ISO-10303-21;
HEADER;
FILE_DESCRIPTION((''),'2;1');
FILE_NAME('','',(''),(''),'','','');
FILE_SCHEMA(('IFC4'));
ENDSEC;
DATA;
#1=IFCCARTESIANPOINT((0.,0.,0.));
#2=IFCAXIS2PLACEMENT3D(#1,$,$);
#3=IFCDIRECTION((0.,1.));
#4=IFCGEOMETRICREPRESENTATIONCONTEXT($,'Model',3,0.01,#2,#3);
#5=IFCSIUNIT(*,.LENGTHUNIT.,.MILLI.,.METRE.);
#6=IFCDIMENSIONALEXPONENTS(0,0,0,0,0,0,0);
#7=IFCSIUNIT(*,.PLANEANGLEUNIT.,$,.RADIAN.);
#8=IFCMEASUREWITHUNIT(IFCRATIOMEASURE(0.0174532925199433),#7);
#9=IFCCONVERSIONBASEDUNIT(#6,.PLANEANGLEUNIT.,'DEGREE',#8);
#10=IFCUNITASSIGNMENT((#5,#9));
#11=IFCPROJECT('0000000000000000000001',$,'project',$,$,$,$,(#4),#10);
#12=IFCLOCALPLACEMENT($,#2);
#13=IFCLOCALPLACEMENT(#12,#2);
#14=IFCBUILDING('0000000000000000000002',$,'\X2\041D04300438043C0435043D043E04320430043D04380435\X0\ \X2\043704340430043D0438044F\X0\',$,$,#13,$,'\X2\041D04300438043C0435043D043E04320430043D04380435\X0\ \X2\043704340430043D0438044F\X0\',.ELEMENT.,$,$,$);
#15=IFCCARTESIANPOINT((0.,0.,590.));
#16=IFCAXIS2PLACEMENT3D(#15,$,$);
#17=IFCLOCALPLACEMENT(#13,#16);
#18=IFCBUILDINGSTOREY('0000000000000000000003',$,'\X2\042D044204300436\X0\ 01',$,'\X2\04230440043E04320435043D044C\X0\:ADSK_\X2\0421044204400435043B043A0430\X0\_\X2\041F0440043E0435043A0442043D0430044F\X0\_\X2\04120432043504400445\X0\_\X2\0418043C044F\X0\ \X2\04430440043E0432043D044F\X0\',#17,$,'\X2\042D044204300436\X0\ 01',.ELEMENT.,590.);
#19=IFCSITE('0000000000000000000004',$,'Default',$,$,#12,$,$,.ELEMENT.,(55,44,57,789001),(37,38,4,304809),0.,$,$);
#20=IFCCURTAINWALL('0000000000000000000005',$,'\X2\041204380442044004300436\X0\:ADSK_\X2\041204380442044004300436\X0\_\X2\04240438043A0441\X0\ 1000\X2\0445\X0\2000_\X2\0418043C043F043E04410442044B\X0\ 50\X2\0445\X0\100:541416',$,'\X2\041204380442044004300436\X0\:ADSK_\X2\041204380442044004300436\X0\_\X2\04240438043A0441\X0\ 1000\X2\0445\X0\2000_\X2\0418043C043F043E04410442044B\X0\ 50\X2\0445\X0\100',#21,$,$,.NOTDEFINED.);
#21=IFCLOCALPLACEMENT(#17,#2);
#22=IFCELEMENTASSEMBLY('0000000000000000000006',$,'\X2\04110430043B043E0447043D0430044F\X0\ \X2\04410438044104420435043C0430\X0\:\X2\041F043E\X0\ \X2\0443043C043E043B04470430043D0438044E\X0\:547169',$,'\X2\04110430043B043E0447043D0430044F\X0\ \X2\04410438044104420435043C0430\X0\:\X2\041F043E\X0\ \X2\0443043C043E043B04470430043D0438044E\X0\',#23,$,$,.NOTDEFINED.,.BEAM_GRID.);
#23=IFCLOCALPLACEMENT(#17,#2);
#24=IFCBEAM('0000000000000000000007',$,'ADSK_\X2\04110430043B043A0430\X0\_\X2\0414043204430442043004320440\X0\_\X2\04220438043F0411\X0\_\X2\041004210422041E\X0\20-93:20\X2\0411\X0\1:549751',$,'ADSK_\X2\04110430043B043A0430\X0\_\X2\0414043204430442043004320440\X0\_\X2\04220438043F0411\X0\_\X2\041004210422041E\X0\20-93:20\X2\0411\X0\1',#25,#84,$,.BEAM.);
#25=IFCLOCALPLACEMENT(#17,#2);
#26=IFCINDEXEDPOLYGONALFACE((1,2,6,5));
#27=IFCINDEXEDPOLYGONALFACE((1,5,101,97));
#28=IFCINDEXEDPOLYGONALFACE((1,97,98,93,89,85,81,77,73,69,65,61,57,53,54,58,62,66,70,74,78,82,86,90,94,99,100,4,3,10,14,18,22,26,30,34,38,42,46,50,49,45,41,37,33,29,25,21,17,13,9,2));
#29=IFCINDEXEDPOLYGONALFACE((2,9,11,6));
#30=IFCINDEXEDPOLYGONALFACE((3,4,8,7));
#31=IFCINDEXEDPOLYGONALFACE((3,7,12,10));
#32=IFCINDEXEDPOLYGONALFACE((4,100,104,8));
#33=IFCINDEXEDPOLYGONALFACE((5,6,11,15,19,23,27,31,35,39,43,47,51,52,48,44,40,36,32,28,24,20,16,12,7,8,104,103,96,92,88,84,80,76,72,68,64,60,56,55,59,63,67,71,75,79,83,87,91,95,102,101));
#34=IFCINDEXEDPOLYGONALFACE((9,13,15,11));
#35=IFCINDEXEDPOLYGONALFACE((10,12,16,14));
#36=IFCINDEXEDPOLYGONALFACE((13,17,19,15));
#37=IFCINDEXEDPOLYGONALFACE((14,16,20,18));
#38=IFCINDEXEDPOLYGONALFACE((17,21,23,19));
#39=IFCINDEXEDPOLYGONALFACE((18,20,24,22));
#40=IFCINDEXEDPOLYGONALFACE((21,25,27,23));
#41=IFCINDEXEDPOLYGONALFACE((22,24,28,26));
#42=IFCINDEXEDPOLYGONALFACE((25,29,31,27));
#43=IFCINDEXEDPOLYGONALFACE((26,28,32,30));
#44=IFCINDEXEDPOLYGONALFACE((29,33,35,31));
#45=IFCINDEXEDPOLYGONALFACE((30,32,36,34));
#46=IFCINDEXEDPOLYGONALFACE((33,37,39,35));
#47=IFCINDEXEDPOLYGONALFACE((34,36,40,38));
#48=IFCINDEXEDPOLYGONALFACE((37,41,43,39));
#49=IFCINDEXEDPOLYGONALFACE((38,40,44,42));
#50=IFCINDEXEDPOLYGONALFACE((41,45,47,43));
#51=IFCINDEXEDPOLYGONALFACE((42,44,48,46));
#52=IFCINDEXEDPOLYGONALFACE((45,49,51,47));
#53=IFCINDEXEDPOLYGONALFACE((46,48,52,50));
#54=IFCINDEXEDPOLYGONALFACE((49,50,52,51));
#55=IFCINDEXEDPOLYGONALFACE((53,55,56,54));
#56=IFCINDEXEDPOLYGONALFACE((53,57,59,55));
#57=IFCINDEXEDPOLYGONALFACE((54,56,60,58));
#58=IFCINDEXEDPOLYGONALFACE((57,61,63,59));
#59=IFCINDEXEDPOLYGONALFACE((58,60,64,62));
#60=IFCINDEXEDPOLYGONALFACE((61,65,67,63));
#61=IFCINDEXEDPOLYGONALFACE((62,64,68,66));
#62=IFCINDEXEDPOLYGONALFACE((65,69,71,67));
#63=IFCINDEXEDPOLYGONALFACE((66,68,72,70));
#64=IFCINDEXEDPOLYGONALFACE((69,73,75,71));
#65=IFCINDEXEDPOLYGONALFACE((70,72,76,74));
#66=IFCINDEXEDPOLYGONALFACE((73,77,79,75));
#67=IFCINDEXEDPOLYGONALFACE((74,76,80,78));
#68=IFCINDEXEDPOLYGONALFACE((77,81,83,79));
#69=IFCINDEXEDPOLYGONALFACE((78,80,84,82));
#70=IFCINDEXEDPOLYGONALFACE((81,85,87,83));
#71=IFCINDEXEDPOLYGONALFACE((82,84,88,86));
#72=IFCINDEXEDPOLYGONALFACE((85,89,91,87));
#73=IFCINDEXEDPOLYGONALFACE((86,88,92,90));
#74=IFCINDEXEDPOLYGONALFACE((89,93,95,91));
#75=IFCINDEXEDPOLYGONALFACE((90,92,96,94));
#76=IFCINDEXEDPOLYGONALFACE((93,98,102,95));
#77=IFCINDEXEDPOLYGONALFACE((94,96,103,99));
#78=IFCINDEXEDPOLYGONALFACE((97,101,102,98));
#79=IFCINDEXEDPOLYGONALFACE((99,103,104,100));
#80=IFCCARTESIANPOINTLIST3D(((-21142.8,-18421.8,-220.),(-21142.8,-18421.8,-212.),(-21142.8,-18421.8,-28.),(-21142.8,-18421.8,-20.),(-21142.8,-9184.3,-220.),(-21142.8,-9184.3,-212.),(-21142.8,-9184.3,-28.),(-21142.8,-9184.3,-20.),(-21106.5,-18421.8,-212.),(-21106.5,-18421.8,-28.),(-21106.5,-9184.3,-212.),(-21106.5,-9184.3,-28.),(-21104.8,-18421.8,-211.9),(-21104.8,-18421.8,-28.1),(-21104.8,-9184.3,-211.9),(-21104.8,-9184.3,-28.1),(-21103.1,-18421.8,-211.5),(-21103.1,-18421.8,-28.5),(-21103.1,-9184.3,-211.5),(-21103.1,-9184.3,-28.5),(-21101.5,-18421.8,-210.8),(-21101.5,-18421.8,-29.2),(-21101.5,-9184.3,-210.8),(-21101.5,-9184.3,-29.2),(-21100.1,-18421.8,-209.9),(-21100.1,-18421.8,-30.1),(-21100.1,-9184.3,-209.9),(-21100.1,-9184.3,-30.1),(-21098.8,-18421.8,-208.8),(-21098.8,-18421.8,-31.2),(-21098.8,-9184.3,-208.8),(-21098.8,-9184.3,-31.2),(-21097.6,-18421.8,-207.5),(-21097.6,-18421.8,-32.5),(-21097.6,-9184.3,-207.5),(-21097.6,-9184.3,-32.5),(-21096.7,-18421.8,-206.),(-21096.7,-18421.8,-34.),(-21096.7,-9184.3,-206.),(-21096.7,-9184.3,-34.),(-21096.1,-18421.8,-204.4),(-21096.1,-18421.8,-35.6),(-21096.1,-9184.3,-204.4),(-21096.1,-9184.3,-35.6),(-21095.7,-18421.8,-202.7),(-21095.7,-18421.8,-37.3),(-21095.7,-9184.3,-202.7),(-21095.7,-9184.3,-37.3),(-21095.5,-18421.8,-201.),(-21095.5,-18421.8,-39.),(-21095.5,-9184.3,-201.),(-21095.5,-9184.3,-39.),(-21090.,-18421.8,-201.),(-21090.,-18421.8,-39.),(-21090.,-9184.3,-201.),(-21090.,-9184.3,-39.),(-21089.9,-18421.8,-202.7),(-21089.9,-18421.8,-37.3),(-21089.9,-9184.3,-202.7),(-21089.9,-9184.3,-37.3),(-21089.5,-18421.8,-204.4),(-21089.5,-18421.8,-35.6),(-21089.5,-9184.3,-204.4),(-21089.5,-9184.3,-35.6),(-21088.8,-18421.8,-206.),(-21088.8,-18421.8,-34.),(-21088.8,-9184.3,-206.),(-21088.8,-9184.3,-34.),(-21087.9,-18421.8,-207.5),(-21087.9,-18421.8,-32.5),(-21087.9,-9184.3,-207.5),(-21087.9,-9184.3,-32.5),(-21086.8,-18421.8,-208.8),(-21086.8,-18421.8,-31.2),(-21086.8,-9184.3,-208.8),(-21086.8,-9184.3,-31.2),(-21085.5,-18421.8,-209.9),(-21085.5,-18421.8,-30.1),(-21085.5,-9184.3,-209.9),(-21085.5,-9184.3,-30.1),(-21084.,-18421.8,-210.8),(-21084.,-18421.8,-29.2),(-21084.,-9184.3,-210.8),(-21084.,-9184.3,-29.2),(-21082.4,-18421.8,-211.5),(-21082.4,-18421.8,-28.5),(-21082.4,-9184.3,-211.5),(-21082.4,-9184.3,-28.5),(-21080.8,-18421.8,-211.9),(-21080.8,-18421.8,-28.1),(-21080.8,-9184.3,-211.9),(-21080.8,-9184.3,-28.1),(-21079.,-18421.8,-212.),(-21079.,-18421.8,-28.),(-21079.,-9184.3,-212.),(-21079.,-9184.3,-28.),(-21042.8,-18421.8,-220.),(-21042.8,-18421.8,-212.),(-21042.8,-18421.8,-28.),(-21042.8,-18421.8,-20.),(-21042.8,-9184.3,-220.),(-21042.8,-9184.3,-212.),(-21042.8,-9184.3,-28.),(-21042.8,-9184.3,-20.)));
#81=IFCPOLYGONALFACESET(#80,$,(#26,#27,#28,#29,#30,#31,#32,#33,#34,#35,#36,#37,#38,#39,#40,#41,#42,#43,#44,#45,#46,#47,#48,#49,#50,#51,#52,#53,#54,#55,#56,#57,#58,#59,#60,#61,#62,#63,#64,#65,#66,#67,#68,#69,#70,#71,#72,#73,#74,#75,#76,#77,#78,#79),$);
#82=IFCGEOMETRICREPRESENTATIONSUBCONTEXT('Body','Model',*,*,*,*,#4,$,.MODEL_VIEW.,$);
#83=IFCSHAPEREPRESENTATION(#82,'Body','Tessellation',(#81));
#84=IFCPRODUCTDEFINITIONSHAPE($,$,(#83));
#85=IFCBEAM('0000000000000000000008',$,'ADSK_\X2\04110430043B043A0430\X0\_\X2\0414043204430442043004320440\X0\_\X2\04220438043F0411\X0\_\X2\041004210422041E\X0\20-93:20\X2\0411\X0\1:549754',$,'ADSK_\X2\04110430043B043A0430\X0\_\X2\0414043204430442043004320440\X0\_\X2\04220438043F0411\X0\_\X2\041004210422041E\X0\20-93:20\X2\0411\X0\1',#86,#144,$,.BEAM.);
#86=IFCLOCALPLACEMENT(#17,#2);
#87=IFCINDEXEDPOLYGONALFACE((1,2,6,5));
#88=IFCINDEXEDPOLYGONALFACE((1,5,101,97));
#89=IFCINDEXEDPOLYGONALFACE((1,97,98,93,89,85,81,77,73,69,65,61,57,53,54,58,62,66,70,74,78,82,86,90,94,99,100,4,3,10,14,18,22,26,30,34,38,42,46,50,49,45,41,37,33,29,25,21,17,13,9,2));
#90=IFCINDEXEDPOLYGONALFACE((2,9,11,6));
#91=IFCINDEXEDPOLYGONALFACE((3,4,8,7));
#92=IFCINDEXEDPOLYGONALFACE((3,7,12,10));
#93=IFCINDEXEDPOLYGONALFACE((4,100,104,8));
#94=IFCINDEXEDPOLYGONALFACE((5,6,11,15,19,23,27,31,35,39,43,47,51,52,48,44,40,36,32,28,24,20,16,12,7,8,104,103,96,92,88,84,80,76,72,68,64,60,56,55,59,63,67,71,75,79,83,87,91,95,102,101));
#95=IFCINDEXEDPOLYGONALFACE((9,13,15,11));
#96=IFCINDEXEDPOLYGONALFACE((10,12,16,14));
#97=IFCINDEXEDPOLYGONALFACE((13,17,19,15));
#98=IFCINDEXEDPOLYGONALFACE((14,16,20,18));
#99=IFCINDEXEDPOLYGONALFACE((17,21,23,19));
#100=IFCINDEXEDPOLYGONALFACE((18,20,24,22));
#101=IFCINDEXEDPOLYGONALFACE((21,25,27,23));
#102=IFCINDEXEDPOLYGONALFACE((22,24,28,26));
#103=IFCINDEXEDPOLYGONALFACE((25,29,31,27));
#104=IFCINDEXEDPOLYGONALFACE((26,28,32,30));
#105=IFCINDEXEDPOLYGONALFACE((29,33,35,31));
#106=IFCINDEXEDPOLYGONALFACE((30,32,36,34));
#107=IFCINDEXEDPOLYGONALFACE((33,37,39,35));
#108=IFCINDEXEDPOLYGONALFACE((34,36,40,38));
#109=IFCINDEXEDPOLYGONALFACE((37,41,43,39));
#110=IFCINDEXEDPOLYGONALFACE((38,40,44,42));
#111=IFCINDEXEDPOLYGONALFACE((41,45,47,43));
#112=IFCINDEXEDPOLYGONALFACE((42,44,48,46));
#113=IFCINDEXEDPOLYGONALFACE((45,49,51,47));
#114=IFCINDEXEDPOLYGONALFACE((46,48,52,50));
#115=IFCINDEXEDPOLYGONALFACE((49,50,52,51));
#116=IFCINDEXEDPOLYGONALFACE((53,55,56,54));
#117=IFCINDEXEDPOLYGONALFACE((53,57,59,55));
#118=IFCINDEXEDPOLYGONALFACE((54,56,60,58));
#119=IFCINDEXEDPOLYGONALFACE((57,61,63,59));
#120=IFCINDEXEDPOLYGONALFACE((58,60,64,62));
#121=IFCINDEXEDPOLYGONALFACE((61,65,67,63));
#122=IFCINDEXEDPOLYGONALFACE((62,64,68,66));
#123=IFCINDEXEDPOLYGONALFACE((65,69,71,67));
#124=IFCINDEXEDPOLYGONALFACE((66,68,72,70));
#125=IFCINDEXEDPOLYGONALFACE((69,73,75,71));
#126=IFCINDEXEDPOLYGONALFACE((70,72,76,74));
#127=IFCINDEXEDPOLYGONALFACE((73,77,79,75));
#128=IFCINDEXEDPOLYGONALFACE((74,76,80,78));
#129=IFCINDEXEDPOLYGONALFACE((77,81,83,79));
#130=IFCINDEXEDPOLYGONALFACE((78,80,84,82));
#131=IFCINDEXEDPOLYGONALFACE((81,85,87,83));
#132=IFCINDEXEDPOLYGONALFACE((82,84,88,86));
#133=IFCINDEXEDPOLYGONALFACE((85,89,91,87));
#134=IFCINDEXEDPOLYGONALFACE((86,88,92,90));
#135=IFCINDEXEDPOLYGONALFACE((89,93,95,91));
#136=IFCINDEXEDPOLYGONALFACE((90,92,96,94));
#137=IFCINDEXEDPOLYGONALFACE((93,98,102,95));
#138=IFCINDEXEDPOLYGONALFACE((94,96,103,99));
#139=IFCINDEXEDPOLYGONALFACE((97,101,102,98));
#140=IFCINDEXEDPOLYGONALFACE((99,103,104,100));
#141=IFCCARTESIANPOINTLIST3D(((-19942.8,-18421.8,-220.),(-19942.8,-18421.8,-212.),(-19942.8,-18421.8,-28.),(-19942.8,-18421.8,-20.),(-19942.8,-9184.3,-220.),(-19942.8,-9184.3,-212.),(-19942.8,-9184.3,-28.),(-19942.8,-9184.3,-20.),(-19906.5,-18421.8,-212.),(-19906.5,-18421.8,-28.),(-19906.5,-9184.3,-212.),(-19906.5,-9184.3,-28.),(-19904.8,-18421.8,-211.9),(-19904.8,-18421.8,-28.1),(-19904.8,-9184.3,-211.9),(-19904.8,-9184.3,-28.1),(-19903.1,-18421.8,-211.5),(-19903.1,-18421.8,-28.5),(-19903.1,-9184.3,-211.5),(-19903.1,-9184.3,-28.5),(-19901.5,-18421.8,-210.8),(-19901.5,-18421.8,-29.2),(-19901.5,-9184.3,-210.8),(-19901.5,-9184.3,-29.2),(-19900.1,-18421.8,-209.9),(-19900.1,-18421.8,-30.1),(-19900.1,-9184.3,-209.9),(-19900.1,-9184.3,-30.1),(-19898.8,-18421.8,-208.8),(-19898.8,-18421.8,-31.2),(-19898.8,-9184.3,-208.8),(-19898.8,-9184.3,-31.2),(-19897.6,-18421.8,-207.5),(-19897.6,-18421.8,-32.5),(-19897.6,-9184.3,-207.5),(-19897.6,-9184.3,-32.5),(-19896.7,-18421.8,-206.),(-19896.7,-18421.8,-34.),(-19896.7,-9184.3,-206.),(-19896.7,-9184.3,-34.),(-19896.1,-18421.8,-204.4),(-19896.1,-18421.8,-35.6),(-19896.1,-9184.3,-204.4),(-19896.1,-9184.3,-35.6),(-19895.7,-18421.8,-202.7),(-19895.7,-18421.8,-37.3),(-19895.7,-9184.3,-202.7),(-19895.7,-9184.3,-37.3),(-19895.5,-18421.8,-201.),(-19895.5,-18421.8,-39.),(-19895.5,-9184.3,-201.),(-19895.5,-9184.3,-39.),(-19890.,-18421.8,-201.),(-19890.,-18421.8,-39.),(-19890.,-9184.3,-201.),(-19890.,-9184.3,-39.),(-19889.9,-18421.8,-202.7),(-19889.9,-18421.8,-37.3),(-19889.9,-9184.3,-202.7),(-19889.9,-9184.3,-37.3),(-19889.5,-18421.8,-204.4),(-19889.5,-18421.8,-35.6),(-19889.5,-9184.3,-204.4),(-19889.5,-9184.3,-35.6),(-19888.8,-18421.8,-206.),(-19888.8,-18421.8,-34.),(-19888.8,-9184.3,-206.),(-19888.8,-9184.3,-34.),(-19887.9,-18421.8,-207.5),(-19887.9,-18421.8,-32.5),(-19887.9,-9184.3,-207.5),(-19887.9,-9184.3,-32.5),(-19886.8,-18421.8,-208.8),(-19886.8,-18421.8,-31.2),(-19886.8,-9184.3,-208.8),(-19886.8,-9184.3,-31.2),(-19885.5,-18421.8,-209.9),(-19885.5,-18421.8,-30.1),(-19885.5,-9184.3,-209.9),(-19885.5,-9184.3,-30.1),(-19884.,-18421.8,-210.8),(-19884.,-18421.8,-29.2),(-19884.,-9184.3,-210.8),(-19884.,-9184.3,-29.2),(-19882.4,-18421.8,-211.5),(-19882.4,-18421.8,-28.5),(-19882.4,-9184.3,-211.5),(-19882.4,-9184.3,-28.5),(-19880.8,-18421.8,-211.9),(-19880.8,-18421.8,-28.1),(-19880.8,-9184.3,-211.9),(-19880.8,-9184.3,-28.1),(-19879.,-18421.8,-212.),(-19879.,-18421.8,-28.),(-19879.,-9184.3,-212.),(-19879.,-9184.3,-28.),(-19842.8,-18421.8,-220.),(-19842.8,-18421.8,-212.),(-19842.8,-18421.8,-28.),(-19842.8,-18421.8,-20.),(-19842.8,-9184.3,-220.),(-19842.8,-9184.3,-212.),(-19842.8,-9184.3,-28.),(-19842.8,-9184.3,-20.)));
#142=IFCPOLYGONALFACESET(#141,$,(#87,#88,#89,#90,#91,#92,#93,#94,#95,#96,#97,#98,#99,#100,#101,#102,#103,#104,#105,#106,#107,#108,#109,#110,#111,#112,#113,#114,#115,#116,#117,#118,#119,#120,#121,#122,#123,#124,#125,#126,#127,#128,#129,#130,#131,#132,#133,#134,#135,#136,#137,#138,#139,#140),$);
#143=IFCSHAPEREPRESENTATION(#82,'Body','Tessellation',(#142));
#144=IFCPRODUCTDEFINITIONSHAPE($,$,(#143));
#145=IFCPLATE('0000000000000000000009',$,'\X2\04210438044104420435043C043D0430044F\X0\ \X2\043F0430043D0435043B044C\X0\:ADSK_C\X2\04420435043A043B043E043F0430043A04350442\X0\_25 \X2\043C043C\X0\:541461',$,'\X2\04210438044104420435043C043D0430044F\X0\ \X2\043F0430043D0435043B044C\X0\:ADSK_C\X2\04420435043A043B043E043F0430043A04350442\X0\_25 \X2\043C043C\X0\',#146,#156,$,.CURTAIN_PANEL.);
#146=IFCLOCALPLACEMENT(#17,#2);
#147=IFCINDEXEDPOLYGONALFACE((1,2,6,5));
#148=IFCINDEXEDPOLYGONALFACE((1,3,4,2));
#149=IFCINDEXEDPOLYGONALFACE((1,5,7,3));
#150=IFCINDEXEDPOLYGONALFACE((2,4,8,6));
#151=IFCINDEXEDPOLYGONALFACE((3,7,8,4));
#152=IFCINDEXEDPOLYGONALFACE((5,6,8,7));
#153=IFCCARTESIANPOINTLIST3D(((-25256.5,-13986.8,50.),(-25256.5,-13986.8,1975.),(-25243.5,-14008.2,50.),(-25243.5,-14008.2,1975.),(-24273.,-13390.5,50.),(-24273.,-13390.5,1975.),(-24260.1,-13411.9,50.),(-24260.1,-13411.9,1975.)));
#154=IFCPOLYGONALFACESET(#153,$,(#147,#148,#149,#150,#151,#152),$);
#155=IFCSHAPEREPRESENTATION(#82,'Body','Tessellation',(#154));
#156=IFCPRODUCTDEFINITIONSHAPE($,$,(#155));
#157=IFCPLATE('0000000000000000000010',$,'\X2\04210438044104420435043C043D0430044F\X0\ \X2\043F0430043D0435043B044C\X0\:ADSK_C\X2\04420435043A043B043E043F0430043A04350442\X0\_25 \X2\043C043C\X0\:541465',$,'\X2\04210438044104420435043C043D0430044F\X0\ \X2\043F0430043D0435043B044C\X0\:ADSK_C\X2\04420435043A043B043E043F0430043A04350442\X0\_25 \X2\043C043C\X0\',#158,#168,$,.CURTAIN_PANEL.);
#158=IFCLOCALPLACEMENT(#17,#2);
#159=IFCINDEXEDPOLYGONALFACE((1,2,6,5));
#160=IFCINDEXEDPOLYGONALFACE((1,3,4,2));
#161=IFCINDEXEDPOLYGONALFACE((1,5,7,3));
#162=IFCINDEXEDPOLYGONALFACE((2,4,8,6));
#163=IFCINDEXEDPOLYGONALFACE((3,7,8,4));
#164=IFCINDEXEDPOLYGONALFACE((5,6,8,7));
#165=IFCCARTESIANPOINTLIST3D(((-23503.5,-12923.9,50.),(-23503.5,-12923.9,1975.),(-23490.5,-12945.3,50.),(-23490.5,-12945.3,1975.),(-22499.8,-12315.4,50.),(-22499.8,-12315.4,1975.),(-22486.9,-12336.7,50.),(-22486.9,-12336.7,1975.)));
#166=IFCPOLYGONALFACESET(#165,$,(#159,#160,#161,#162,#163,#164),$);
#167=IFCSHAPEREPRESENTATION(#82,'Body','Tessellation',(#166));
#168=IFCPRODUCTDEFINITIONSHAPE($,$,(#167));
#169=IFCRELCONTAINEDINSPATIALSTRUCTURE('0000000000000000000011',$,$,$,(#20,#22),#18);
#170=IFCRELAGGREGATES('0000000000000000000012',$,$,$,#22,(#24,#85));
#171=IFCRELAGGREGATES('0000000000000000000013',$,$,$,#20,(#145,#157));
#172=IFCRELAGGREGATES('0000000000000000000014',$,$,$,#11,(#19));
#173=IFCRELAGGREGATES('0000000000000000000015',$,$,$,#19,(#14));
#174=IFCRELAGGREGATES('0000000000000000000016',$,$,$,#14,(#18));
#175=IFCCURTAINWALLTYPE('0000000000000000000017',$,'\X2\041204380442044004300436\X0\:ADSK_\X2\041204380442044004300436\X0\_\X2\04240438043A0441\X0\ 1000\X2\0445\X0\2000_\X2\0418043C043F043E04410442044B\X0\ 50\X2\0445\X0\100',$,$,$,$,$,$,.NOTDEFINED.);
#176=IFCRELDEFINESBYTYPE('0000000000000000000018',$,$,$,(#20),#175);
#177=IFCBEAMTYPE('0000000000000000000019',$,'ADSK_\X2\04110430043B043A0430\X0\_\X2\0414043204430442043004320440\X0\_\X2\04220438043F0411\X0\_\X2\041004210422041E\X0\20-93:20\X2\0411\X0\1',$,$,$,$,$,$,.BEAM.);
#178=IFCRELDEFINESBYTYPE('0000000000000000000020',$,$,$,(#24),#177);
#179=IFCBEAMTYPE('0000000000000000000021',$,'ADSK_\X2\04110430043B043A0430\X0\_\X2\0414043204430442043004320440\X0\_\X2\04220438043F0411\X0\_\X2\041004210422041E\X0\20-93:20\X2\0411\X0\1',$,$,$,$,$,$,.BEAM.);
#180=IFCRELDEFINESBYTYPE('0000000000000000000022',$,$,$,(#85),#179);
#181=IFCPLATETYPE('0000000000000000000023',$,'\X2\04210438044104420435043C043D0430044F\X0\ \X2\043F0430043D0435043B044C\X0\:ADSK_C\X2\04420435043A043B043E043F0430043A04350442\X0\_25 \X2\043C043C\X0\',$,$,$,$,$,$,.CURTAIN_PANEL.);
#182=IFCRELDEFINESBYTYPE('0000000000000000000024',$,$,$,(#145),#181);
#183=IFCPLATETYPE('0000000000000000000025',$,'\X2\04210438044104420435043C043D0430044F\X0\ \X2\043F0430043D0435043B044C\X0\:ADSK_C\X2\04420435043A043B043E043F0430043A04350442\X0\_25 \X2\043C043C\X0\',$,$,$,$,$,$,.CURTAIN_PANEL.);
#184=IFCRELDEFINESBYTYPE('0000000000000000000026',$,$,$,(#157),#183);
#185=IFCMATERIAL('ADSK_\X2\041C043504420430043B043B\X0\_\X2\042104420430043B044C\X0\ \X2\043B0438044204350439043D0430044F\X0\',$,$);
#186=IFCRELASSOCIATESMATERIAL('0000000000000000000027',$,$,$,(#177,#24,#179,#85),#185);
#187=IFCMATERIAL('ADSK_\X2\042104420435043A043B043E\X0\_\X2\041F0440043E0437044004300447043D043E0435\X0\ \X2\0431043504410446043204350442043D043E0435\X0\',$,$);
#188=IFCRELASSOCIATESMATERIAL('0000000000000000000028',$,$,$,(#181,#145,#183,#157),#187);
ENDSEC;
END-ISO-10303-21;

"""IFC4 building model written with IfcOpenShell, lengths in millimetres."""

from ifc_helpers import new_model, entity, si_unit, converted_unit, direction, frame, origin, place, context, subcontext, project, spatial, indexed_curve, outline, extrude, source, transform, mapped, material, type_object, type_shapes, element, aggregate, save


model = new_model("IFC4")

# Units and contexts
model_context = context("Model", 3, precision=0.01, world=origin(), true_north=direction((0.0, 1.0)))
body_context = subcontext(model_context, "Body", "Model", "MODEL_VIEW")
ifc_project = project(units=[si_unit("LENGTHUNIT", "METRE", prefix="MILLI"), converted_unit("PLANEANGLEUNIT", "DEGREE", entity("IfcRatioMeasure", 0.0174532925199433), si_unit("PLANEANGLEUNIT", "RADIAN"), dimensions=[0, 0, 0, 0, 0, 0, 0])], contexts=[model_context])

# Site, building, storey
site_placement = place(None, origin())
site = spatial("IfcSite", under=ifc_project, at=site_placement, Name="Default", CompositionType="ELEMENT", RefLatitude=(55, 44, 57, 789001), RefLongitude=(37, 38, 4, 304809), RefElevation=0.0)
building_placement = place(site_placement, origin())
building = spatial("IfcBuilding", under=site, at=building_placement, Name="Наименование здания", LongName="Наименование здания", CompositionType="ELEMENT")
storey_placement = place(building_placement, frame((0.0, 0.0, 590.0)))
storey = spatial("IfcBuildingStorey", under=building, at=storey_placement, Name="Этаж 01", ObjectType="Уровень:ADSK_Стрелка_Проектная_Вверх_Имя уровня", LongName="Этаж 01", CompositionType="ELEMENT", Elevation=590.0)

# Curtain wall
curtain_wall_type = type_object("IfcCurtainWallType", Name="Витраж:ADSK_Витраж_Фикс 1000х2000_Импосты 50х100", PredefinedType="NOTDEFINED")
curtain_wall_placement = place(storey_placement, frame((0.0, 0.0, -590.0)))
curtain_wall = element("IfcCurtainWall", 1, at=curtain_wall_placement, inside=storey, type_object=curtain_wall_type, Name="Витраж:ADSK_Витраж_Фикс 1000х2000_Импосты 50х100:541416", ObjectType="Витраж:ADSK_Витраж_Фикс 1000х2000_Импосты 50х100", PredefinedType="NOTDEFINED")

# Element assembly, beams
assembly_placement = place(storey_placement, origin())
assembly = element("IfcElementAssembly", 2, at=assembly_placement, inside=storey, Name="Балочная система:По умолчанию:547169", ObjectType="Балочная система:По умолчанию", AssemblyPlace="NOTDEFINED", PredefinedType="BEAM_GRID")
ifc_material_1 = material(Name="ADSK_Металл_Сталь литейная")
beam_type_1 = type_object("IfcBeamType", Name="ADSK_Балка_Двутавр_ТипБ_АСТО20-93:20Б1", PredefinedType="BEAM", material=ifc_material_1)
shared_shape_1 = source(origin(), body_context, "Body", "SweptSolid", [
    extrude(outline(indexed_curve([(-100.0, -50.0), (-92.0, -50.0), (-92.0, -13.8), (-91.9, -12.0), (-91.5, -10.4), (-90.8, -8.8), (-89.9, -7.3), (-88.8, -6.0), (-87.5, -4.9), (-86.0, -3.9), (-84.4, -3.3), (-82.7, -2.9), (-81.0, -2.8), (81.0, -2.8), (82.7, -2.9), (84.4, -3.3), (86.0, -3.9), (87.5, -4.9), (88.8, -6.0), (89.9, -7.3), (90.8, -8.8), (91.5, -10.4), (91.9, -12.0), (92.0, -13.7), (92.0, -50.0), (100.0, -50.0), (100.0, 50.0), (92.0, 50.0), (92.0, 13.8), (91.9, 12.0), (91.5, 10.4), (90.8, 8.8), (89.9, 7.3), (88.8, 6.0), (87.5, 4.9), (86.0, 3.9), (84.4, 3.3), (82.7, 2.9), (81.0, 2.8), (-81.0, 2.8), (-82.7, 2.9), (-84.4, 3.3), (-86.0, 3.9), (-87.5, 4.9), (-88.8, 6.0), (-89.9, 7.3), (-90.8, 8.8), (-91.5, 10.4), (-91.9, 12.0), (-92.0, 13.8), (-92.0, 50.0), (-100.0, 50.0), (-100.0, -50.0)], self_intersect=False)), frame((-4618.7, 0.0, -100.0), z_axis=(1.0, 0.0, 0.0), x_axis=(0.0, 0.0, -1.0)), (0.0, 0.0, 1.0), 9237.5),
])
type_shapes(beam_type_1, [shared_shape_1])
beam_1_placement = place(assembly_placement, frame((-21092.8, -13803.0, -20.0), z_axis=(0.0, 0.0, 1.0), x_axis=(0.0, 1.0, 0.0)))
beam_1 = element("IfcBeam", 3, at=beam_1_placement, type_object=beam_type_1, material=ifc_material_1, Name="ADSK_Балка_Двутавр_ТипБ_АСТО20-93:20Б1:549751", ObjectType="ADSK_Балка_Двутавр_ТипБ_АСТО20-93:20Б1", PredefinedType="BEAM", context=body_context, shape_type="MappedRepresentation", body=[
    mapped(shared_shape_1, transform((0.0, 0.0, 0.0), scale=1.0)),
])
beam_type_2 = type_object("IfcBeamType", Name="ADSK_Балка_Двутавр_ТипБ_АСТО20-93:20Б1", PredefinedType="BEAM", material=ifc_material_1)
shared_shape_2 = source(origin(), body_context, "Body", "SweptSolid", [
    extrude(outline(indexed_curve([(-100.0, -50.0), (-92.0, -50.0), (-92.0, -13.8), (-91.9, -12.0), (-91.5, -10.4), (-90.8, -8.8), (-89.9, -7.3), (-88.8, -6.0), (-87.5, -4.9), (-86.0, -3.9), (-84.4, -3.3), (-82.7, -2.9), (-81.0, -2.8), (81.0, -2.8), (82.7, -2.9), (84.4, -3.3), (86.0, -3.9), (87.5, -4.9), (88.8, -6.0), (89.9, -7.3), (90.8, -8.8), (91.5, -10.4), (91.9, -12.0), (92.0, -13.7), (92.0, -50.0), (100.0, -50.0), (100.0, 50.0), (92.0, 50.0), (92.0, 13.8), (91.9, 12.0), (91.5, 10.4), (90.8, 8.8), (89.9, 7.3), (88.8, 6.0), (87.5, 4.9), (86.0, 3.9), (84.4, 3.3), (82.7, 2.9), (81.0, 2.8), (-81.0, 2.8), (-82.7, 2.9), (-84.4, 3.3), (-86.0, 3.9), (-87.5, 4.9), (-88.8, 6.0), (-89.9, 7.3), (-90.8, 8.8), (-91.5, 10.4), (-91.9, 12.0), (-92.0, 13.8), (-92.0, 50.0), (-100.0, 50.0), (-100.0, -50.0)], self_intersect=False)), frame((-4618.7, 0.0, -100.0), z_axis=(1.0, 0.0, 0.0), x_axis=(0.0, 0.0, -1.0)), (0.0, 0.0, 1.0), 9237.5),
])
type_shapes(beam_type_2, [shared_shape_2])
beam_2_placement = place(assembly_placement, frame((-19892.8, -13803.0, -20.0), z_axis=(0.0, 0.0, 1.0), x_axis=(0.0, 1.0, 0.0)))
beam_2 = element("IfcBeam", 4, at=beam_2_placement, type_object=beam_type_2, material=ifc_material_1, Name="ADSK_Балка_Двутавр_ТипБ_АСТО20-93:20Б1:549754", ObjectType="ADSK_Балка_Двутавр_ТипБ_АСТО20-93:20Б1", PredefinedType="BEAM", context=body_context, shape_type="MappedRepresentation", body=[
    mapped(shared_shape_2, transform((0.0, 0.0, 0.0), scale=1.0)),
])
aggregate(assembly, [beam_1, beam_2])

# Plates
ifc_material_2 = material(Name="ADSK_Стекло_Прозрачное бесцветное")
plate_type_1 = type_object("IfcPlateType", Name="Системная панель:ADSK_Cтеклопакет_25 мм", PredefinedType="CURTAIN_PANEL", material=ifc_material_2)
shared_shape_3 = source(origin(), body_context, "Body", "SweptSolid", [
    extrude(outline(indexed_curve([(-12.5, -575.1), (12.5, -575.1), (12.5, 575.1), (-12.5, 575.1), (-12.5, -575.1)], self_intersect=False)), frame((0.0, 0.0, 0.0), z_axis=(0.0, 0.0, 1.0), x_axis=(0.0, 1.0, 0.0)), (0.0, 0.0, 1.0), 1925.0),
])
type_shapes(plate_type_1, [shared_shape_3])
plate_1_placement = place(curtain_wall_placement, frame((-24758.3, -13699.3, 640.0), z_axis=(0.0, 0.0, 1.0), x_axis=(0.855102, 0.51846, 0.0)))
plate_1 = element("IfcPlate", 5, at=plate_1_placement, type_object=plate_type_1, material=ifc_material_2, Name="Системная панель:ADSK_Cтеклопакет_25 мм:541461", ObjectType="Системная панель:ADSK_Cтеклопакет_25 мм", PredefinedType="CURTAIN_PANEL", context=body_context, shape_type="MappedRepresentation", body=[
    mapped(shared_shape_3, transform((0.0, 0.0, 0.0), scale=1.0)),
])
plate_type_2 = type_object("IfcPlateType", Name="Системная панель:ADSK_Cтеклопакет_25 мм", PredefinedType="CURTAIN_PANEL", material=ifc_material_2)
shared_shape_4 = source(origin(), body_context, "Body", "SweptSolid", [
    extrude(outline(indexed_curve([(-12.5, -586.9), (12.5, -586.9), (12.5, 586.9), (-12.5, 586.9), (-12.5, -586.9)], self_intersect=False)), frame((0.0, 0.0, 0.0), z_axis=(0.0, 0.0, 1.0), x_axis=(0.0, 1.0, 0.0)), (0.0, 0.0, 1.0), 1925.0),
])
type_shapes(plate_type_2, [shared_shape_4])
plate_2_placement = place(curtain_wall_placement, frame((-22995.2, -12630.3, 640.0), z_axis=(0.0, 0.0, 1.0), x_axis=(0.855102, 0.51846, 0.0)))
plate_2 = element("IfcPlate", 6, at=plate_2_placement, type_object=plate_type_2, material=ifc_material_2, Name="Системная панель:ADSK_Cтеклопакет_25 мм:541465", ObjectType="Системная панель:ADSK_Cтеклопакет_25 мм", PredefinedType="CURTAIN_PANEL", context=body_context, shape_type="MappedRepresentation", body=[
    mapped(shared_shape_4, transform((0.0, 0.0, 0.0), scale=1.0)),
])
aggregate(curtain_wall, [plate_1, plate_2])

save(model, "model.ifc")
